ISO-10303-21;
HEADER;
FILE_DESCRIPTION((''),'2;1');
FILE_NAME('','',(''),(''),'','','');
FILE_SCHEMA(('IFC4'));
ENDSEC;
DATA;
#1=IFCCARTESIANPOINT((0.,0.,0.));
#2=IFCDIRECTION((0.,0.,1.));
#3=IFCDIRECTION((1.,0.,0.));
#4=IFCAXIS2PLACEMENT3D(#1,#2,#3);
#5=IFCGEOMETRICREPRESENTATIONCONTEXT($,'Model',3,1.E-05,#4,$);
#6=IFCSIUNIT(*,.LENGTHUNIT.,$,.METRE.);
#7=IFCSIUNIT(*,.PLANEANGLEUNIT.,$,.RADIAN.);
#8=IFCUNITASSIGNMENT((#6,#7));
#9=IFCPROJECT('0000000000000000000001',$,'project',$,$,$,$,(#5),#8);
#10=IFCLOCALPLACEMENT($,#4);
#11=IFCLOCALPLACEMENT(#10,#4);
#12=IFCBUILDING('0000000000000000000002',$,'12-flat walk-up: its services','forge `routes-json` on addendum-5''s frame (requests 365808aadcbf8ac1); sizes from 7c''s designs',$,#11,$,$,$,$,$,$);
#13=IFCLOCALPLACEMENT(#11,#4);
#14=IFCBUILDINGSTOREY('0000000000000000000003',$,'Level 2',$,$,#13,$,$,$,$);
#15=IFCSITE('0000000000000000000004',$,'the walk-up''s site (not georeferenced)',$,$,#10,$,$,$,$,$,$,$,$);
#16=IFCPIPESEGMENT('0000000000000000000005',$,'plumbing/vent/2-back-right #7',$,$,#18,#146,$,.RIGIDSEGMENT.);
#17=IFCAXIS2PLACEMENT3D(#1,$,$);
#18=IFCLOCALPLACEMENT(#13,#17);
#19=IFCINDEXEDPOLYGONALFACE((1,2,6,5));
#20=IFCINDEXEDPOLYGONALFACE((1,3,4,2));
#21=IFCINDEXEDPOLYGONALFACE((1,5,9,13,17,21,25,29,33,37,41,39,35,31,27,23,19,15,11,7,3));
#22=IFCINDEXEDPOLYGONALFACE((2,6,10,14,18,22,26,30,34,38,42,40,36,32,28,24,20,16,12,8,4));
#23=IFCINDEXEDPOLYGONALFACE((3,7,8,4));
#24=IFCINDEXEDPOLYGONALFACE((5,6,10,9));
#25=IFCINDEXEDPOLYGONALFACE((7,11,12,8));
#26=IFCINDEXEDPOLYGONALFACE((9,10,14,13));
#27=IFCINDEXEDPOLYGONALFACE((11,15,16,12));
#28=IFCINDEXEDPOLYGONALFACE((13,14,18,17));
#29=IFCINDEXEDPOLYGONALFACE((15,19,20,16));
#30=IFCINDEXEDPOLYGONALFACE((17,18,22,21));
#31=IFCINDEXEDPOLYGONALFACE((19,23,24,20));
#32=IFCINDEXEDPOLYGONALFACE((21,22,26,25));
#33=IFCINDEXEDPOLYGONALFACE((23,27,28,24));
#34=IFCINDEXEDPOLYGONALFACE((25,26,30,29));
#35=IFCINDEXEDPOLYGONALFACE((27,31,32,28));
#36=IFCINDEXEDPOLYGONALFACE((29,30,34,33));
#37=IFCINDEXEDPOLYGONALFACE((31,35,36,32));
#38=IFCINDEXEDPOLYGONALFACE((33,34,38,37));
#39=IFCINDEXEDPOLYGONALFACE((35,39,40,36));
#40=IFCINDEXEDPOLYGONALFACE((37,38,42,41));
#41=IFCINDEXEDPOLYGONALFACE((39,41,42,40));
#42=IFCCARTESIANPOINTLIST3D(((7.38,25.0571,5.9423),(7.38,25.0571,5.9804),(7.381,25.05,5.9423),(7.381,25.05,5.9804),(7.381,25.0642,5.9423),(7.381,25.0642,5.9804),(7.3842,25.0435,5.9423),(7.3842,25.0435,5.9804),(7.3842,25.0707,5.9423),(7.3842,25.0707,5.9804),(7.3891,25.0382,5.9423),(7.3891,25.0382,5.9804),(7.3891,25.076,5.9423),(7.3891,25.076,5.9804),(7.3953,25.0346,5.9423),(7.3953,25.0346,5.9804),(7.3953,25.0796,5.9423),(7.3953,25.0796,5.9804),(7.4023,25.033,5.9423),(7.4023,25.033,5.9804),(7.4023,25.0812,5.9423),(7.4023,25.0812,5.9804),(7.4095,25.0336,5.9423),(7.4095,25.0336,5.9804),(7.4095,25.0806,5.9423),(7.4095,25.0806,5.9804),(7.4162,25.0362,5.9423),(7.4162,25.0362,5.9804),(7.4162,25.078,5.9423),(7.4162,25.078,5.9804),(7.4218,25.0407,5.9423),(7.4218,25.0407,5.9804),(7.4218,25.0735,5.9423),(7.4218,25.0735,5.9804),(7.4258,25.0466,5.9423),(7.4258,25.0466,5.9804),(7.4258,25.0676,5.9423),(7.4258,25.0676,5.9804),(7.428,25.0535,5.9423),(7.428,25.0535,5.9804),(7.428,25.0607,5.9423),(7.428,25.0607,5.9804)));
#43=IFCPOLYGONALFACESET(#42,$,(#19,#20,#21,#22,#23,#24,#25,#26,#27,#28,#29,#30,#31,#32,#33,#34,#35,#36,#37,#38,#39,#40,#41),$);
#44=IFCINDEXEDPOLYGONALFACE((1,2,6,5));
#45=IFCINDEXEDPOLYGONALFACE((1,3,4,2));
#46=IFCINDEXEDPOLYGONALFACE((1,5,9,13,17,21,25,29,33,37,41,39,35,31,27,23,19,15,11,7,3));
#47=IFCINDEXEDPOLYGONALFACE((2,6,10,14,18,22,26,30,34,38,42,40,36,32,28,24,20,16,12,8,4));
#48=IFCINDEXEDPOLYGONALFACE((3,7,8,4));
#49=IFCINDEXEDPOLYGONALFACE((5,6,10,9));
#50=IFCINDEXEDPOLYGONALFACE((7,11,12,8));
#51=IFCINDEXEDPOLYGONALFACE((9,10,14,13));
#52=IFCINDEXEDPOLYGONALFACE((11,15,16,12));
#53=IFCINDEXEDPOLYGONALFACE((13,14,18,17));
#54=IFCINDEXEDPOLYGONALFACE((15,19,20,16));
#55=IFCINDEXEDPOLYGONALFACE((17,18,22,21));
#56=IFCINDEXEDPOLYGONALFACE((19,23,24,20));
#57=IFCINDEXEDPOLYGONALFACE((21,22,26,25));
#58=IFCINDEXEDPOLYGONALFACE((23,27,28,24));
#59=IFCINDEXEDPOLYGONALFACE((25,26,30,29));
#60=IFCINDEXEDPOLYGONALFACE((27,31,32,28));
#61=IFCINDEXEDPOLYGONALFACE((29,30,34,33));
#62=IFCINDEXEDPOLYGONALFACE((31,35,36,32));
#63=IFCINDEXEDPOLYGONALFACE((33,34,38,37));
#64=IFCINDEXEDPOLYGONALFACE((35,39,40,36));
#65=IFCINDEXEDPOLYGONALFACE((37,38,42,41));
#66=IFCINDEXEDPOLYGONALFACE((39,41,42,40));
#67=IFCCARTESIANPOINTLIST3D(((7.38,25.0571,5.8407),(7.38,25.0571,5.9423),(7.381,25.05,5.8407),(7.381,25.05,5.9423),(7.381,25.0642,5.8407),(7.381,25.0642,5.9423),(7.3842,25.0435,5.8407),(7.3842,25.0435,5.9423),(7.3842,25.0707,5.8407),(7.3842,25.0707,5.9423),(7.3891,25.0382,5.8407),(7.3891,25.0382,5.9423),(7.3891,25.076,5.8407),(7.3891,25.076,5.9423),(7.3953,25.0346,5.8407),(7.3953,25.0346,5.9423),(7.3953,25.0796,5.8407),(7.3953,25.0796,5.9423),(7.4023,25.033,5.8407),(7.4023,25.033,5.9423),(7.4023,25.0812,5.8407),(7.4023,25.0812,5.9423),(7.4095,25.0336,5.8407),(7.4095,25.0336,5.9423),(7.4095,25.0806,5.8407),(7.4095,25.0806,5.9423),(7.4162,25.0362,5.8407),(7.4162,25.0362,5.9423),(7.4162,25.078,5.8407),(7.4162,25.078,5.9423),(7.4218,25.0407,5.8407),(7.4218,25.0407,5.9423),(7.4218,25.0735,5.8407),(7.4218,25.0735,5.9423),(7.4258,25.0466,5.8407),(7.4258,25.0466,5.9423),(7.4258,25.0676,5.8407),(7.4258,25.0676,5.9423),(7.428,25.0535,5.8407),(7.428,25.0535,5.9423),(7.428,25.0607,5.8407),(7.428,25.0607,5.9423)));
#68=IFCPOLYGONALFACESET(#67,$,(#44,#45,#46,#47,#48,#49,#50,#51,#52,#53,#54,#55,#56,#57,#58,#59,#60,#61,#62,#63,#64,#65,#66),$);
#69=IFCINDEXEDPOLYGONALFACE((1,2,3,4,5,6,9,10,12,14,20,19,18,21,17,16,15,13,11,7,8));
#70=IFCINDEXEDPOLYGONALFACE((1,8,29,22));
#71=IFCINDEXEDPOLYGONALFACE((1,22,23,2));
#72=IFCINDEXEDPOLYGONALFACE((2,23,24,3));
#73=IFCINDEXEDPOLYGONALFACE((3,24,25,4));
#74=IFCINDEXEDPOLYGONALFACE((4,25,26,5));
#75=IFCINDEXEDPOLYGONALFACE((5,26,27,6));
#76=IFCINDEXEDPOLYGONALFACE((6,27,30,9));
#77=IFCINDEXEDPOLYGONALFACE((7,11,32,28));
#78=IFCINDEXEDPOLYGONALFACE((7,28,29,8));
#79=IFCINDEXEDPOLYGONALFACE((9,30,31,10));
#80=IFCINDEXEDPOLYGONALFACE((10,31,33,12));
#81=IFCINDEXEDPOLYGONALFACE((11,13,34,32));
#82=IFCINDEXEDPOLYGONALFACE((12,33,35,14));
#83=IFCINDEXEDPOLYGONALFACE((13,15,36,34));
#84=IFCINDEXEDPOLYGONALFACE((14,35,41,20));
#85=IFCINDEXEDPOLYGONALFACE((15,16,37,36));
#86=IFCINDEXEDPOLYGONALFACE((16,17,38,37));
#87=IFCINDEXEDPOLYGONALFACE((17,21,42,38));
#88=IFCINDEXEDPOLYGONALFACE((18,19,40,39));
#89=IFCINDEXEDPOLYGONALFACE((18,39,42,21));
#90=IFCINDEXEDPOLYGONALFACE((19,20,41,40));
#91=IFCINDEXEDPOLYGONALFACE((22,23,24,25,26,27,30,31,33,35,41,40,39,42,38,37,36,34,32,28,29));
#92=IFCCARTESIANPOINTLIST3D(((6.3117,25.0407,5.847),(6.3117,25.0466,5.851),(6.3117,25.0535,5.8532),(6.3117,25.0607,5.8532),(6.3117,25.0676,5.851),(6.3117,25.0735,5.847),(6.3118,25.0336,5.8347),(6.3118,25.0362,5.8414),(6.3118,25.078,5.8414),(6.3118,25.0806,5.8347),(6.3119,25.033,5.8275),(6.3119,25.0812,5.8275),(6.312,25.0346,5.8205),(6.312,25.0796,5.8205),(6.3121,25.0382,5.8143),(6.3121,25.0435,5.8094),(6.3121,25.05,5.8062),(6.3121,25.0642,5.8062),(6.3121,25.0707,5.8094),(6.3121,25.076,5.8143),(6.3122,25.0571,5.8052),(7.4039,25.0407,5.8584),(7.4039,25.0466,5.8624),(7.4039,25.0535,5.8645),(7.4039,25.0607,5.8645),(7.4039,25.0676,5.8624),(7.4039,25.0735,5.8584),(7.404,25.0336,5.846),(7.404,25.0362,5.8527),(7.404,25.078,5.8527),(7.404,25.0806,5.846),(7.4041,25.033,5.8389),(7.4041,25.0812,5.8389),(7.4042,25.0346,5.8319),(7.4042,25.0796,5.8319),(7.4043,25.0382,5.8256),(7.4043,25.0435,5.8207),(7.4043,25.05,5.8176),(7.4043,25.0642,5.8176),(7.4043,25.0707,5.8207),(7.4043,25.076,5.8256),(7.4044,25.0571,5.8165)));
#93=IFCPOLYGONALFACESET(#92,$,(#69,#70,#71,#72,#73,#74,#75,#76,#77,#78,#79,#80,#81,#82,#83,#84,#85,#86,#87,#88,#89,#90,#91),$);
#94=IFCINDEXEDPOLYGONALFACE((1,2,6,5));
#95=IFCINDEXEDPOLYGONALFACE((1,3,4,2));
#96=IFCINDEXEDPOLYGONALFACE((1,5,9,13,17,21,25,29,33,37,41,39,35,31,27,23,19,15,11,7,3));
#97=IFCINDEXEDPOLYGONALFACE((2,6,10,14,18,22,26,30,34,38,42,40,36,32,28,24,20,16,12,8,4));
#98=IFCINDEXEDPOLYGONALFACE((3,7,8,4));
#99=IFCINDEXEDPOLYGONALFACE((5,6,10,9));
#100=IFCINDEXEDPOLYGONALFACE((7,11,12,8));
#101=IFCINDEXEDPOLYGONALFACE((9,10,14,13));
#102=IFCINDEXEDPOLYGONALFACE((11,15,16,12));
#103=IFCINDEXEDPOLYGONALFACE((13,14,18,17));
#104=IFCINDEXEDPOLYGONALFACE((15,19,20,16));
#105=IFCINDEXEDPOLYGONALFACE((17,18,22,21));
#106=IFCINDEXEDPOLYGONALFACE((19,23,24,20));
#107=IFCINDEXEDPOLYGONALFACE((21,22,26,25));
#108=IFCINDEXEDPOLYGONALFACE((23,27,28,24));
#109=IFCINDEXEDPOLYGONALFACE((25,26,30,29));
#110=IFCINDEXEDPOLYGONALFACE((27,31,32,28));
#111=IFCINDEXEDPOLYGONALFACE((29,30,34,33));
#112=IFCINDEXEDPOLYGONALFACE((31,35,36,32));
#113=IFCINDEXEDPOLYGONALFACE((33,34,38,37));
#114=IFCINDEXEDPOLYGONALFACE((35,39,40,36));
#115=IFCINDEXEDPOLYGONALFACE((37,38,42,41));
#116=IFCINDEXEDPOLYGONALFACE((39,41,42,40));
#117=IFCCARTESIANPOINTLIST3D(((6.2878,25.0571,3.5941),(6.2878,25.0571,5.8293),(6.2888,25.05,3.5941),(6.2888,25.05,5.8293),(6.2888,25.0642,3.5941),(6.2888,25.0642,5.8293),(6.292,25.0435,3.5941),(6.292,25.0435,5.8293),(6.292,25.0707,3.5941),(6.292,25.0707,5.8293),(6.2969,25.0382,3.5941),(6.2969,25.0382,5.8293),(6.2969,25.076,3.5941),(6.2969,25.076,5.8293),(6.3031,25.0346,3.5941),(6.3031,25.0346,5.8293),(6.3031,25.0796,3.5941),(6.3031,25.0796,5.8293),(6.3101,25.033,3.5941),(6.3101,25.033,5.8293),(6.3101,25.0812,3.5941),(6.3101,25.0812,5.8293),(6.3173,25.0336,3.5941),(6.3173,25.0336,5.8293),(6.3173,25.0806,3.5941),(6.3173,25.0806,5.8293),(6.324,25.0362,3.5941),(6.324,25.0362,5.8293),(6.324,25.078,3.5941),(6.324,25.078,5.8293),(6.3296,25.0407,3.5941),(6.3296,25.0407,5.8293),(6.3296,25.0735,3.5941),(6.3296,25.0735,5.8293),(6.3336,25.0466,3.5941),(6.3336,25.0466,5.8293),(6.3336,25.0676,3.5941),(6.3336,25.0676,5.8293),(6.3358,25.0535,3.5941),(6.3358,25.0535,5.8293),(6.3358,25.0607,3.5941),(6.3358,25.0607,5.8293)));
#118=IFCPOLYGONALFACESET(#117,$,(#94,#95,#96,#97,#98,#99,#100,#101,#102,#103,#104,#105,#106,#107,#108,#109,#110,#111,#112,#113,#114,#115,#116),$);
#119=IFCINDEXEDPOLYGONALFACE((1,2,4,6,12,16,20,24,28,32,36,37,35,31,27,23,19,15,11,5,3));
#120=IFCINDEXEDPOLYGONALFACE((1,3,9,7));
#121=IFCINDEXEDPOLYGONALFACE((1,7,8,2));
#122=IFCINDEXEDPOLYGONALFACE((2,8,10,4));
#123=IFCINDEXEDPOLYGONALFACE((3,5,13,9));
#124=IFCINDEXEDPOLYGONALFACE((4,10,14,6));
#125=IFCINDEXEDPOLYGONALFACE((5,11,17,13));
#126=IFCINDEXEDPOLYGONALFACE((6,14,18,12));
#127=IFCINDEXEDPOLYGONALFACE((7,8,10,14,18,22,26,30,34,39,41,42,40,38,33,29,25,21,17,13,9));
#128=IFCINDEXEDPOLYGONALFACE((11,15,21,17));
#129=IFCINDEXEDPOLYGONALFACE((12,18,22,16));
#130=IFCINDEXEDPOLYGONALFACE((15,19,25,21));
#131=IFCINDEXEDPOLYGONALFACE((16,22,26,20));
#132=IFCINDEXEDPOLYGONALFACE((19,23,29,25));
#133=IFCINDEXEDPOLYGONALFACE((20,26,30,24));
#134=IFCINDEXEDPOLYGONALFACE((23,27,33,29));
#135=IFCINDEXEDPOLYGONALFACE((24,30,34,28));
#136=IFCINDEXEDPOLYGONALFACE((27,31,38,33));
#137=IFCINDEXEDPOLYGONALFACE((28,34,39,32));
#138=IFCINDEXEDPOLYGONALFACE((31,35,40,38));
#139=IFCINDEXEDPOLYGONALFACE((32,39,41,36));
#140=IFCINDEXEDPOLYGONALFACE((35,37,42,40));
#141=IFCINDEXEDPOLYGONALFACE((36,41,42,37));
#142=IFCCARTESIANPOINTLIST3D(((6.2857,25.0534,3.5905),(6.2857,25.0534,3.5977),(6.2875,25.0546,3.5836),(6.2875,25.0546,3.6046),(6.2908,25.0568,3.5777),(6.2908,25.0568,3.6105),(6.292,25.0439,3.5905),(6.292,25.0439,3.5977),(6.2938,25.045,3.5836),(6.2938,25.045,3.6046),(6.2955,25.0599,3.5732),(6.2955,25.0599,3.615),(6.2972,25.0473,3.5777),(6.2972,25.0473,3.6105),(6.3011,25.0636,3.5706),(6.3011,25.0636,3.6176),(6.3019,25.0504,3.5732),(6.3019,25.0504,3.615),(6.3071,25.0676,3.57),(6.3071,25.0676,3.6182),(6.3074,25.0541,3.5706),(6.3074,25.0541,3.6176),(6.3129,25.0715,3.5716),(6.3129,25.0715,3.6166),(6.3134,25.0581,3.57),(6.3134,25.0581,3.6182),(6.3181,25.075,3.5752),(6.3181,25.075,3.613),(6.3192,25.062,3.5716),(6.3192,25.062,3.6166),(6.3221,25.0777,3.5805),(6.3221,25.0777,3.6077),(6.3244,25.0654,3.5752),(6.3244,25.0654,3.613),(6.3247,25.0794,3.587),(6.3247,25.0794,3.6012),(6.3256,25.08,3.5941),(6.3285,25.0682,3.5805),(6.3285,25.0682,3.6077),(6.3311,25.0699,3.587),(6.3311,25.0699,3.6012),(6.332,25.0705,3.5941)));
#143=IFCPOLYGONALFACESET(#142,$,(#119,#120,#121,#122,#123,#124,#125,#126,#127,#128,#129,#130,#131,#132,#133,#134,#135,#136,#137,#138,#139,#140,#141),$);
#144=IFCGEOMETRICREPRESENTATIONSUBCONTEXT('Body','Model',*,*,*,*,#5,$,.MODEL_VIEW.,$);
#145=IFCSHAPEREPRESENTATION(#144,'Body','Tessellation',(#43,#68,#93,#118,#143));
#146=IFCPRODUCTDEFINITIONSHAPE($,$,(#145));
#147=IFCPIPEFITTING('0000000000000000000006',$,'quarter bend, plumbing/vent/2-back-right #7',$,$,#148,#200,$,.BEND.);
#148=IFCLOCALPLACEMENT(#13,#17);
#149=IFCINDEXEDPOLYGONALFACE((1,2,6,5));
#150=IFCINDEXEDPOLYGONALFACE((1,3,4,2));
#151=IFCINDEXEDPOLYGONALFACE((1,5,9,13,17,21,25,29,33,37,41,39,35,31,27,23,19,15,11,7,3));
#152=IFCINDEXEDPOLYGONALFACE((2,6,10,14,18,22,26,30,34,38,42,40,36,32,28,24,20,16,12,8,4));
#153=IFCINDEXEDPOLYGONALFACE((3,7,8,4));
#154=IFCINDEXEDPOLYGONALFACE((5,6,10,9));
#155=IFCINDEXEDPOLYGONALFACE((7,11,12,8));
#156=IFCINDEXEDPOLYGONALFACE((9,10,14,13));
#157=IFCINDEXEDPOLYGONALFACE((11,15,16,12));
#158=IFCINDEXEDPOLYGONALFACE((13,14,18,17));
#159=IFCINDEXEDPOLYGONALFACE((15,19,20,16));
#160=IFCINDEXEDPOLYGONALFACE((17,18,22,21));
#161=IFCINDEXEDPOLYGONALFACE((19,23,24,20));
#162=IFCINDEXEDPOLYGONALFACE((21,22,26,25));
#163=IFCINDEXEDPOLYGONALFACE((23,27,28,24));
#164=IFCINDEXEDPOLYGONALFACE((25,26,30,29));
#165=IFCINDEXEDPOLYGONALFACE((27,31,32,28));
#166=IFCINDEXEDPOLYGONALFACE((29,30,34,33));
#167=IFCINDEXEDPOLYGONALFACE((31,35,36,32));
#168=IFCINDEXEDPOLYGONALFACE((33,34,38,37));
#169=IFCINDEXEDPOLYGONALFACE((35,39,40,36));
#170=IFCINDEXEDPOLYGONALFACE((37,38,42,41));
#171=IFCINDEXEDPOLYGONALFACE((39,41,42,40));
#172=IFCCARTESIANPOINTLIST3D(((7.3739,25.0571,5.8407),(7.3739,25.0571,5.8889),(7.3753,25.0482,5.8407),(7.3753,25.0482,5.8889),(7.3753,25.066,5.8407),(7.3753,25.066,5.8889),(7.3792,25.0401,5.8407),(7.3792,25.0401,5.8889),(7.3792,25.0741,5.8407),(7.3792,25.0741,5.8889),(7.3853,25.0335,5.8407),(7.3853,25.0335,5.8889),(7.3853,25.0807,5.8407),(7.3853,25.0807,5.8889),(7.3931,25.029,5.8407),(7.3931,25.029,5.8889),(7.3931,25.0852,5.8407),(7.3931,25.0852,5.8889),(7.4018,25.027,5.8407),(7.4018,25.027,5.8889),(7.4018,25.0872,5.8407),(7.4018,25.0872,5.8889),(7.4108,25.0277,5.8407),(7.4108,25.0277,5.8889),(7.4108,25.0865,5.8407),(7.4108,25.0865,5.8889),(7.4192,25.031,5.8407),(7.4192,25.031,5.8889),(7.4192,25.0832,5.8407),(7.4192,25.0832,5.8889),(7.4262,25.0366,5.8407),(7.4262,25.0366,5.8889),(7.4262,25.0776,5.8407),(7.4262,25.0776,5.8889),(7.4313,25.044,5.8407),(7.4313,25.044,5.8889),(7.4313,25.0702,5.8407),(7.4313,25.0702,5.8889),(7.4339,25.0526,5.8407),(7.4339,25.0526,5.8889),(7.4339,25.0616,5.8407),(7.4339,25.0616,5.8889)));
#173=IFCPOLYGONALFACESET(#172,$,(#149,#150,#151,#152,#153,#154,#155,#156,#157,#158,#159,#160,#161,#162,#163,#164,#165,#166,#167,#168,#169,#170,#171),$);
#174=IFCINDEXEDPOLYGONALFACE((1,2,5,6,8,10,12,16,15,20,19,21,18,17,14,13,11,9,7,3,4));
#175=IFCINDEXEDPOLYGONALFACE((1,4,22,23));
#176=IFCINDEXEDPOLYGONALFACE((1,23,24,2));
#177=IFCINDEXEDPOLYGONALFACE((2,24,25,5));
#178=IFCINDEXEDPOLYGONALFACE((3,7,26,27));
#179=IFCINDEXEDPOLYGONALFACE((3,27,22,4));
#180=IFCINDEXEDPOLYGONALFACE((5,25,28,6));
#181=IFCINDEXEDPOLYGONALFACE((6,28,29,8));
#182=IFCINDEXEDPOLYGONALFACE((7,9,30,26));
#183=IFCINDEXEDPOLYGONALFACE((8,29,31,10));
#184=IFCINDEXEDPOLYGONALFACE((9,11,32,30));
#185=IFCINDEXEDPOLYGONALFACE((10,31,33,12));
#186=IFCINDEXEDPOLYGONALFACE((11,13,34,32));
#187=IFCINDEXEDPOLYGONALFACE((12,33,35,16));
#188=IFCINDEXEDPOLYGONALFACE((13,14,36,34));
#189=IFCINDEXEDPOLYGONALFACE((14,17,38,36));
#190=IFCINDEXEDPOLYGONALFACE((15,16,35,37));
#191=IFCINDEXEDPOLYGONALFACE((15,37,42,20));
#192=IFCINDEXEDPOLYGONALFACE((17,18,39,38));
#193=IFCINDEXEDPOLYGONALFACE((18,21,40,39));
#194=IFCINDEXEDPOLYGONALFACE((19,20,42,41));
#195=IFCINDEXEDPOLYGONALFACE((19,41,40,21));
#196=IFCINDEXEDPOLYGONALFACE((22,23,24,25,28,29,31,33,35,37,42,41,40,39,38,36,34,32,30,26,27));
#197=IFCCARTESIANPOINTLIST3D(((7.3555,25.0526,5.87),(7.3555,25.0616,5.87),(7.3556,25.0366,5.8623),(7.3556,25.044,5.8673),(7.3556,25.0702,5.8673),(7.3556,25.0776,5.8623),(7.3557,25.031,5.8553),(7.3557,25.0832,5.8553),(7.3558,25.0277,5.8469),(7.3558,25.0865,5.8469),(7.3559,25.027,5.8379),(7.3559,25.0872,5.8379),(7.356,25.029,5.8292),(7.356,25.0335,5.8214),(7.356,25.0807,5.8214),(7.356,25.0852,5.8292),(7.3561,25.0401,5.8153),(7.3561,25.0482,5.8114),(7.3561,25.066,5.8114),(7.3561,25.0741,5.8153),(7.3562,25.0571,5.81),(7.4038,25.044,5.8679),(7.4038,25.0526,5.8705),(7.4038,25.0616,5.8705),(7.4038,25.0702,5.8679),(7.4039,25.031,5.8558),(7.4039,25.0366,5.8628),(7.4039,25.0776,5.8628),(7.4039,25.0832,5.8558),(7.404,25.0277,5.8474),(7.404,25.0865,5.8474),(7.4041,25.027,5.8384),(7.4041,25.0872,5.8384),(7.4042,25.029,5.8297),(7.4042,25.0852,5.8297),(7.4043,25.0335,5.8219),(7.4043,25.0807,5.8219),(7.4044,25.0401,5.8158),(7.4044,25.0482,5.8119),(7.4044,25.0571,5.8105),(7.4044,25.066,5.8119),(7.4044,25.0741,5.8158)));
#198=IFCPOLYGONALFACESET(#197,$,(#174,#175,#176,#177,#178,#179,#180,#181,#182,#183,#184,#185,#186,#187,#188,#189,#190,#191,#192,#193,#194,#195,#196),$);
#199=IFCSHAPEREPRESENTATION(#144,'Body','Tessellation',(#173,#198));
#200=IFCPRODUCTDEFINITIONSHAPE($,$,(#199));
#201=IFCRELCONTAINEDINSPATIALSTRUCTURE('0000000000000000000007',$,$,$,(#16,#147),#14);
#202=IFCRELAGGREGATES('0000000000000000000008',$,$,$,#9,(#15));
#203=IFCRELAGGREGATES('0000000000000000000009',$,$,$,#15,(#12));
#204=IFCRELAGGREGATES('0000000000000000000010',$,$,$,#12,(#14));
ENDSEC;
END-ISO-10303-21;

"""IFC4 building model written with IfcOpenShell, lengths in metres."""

from ifc_helpers import new_model, entity, si_unit, frame, origin_with_axes, place, context, subcontext, project, spatial, element, save


model = new_model("IFC4")

# Units and contexts
model_context = context("Model", 3, precision=1e-05, world=origin_with_axes())
body_context = subcontext(model_context, "Body", "Model", "MODEL_VIEW")
ifc_project = project(units=[si_unit("LENGTHUNIT", "METRE"), si_unit("PLANEANGLEUNIT", "RADIAN")], contexts=[model_context])

# Site, building, storey
site_placement = place(None, origin_with_axes())
site = spatial("IfcSite", under=ifc_project, at=site_placement, Name="the walk-up's site (not georeferenced)")
building_placement = place(site_placement, origin_with_axes())
building = spatial("IfcBuilding", under=site, at=building_placement, Name="12-flat walk-up: its services", Description="forge `routes-json` on addendum-5's frame (requests 365808aadcbf8ac1); sizes from 7c's designs")
storey_placement = place(building_placement, origin_with_axes())
storey = spatial("IfcBuildingStorey", under=building, at=storey_placement, Name="Level 2")

# Pipe segment
pipe_segment_1_placement = place(storey_placement, frame((7.4041, 25.0571, 5.9804), z_axis=(0.0, 0.0, 1.0), x_axis=(1.0, 0.0, 0.0)))
element("IfcPipeSegment", 1, at=pipe_segment_1_placement, inside=storey, Name="plumbing/vent/2-back-right #7", PredefinedType="RIGIDSEGMENT", context=body_context, shape_type="AdvancedSweptSolid", body=[
    entity("IfcSweptDiskSolid", entity("IfcPolyline", [entity("IfcCartesianPoint", [0.0, 0.0, 0.0]), entity("IfcCartesianPoint", [0.0, 0.0, -0.0381])]), 0.0241),
    entity("IfcSweptDiskSolid", entity("IfcPolyline", [entity("IfcCartesianPoint", [0.0, 0.0, -0.0381]), entity("IfcCartesianPoint", [0.0, 0.0, -0.1397])]), 0.0241),
    entity("IfcSweptDiskSolid", entity("IfcPolyline", [entity("IfcCartesianPoint", [0.0, 0.0, -0.1397]), entity("IfcCartesianPoint", [-1.0922, 0.0, -0.1511])]), 0.0241),
    entity("IfcSweptDiskSolid", entity("IfcPolyline", [entity("IfcCartesianPoint", [-1.0922, 0.0, -0.1511]), entity("IfcCartesianPoint", [-1.0922, 0.0, -2.3863])]), 0.0241),
    entity("IfcSweptDiskSolid", entity("IfcPolyline", [entity("IfcCartesianPoint", [-1.0922, 0.0, -2.3863]), entity("IfcCartesianPoint", [-1.0985, 0.0095, -2.3863])]), 0.0241),
])

# Pipe fitting
pipe_fitting_1_placement = place(storey_placement, frame((7.4041, 25.0571, 5.8889), z_axis=(0.0, 0.0, 1.0), x_axis=(1.0, 0.0, 0.0)))
element("IfcPipeFitting", 2, at=pipe_fitting_1_placement, inside=storey, Name="quarter bend, plumbing/vent/2-back-right #7", PredefinedType="BEND", context=body_context, shape_type="AdvancedSweptSolid", body=[
    entity("IfcSweptDiskSolid", entity("IfcPolyline", [entity("IfcCartesianPoint", [0.0, 0.0, 0.0]), entity("IfcCartesianPoint", [0.0, 0.0, -0.0483])]), 0.0302),
    entity("IfcSweptDiskSolid", entity("IfcPolyline", [entity("IfcCartesianPoint", [0.0, 0.0, -0.0483]), entity("IfcCartesianPoint", [-0.0483, 0.0, -0.0488])]), 0.0302),
])

save(model, "model.ifc")
